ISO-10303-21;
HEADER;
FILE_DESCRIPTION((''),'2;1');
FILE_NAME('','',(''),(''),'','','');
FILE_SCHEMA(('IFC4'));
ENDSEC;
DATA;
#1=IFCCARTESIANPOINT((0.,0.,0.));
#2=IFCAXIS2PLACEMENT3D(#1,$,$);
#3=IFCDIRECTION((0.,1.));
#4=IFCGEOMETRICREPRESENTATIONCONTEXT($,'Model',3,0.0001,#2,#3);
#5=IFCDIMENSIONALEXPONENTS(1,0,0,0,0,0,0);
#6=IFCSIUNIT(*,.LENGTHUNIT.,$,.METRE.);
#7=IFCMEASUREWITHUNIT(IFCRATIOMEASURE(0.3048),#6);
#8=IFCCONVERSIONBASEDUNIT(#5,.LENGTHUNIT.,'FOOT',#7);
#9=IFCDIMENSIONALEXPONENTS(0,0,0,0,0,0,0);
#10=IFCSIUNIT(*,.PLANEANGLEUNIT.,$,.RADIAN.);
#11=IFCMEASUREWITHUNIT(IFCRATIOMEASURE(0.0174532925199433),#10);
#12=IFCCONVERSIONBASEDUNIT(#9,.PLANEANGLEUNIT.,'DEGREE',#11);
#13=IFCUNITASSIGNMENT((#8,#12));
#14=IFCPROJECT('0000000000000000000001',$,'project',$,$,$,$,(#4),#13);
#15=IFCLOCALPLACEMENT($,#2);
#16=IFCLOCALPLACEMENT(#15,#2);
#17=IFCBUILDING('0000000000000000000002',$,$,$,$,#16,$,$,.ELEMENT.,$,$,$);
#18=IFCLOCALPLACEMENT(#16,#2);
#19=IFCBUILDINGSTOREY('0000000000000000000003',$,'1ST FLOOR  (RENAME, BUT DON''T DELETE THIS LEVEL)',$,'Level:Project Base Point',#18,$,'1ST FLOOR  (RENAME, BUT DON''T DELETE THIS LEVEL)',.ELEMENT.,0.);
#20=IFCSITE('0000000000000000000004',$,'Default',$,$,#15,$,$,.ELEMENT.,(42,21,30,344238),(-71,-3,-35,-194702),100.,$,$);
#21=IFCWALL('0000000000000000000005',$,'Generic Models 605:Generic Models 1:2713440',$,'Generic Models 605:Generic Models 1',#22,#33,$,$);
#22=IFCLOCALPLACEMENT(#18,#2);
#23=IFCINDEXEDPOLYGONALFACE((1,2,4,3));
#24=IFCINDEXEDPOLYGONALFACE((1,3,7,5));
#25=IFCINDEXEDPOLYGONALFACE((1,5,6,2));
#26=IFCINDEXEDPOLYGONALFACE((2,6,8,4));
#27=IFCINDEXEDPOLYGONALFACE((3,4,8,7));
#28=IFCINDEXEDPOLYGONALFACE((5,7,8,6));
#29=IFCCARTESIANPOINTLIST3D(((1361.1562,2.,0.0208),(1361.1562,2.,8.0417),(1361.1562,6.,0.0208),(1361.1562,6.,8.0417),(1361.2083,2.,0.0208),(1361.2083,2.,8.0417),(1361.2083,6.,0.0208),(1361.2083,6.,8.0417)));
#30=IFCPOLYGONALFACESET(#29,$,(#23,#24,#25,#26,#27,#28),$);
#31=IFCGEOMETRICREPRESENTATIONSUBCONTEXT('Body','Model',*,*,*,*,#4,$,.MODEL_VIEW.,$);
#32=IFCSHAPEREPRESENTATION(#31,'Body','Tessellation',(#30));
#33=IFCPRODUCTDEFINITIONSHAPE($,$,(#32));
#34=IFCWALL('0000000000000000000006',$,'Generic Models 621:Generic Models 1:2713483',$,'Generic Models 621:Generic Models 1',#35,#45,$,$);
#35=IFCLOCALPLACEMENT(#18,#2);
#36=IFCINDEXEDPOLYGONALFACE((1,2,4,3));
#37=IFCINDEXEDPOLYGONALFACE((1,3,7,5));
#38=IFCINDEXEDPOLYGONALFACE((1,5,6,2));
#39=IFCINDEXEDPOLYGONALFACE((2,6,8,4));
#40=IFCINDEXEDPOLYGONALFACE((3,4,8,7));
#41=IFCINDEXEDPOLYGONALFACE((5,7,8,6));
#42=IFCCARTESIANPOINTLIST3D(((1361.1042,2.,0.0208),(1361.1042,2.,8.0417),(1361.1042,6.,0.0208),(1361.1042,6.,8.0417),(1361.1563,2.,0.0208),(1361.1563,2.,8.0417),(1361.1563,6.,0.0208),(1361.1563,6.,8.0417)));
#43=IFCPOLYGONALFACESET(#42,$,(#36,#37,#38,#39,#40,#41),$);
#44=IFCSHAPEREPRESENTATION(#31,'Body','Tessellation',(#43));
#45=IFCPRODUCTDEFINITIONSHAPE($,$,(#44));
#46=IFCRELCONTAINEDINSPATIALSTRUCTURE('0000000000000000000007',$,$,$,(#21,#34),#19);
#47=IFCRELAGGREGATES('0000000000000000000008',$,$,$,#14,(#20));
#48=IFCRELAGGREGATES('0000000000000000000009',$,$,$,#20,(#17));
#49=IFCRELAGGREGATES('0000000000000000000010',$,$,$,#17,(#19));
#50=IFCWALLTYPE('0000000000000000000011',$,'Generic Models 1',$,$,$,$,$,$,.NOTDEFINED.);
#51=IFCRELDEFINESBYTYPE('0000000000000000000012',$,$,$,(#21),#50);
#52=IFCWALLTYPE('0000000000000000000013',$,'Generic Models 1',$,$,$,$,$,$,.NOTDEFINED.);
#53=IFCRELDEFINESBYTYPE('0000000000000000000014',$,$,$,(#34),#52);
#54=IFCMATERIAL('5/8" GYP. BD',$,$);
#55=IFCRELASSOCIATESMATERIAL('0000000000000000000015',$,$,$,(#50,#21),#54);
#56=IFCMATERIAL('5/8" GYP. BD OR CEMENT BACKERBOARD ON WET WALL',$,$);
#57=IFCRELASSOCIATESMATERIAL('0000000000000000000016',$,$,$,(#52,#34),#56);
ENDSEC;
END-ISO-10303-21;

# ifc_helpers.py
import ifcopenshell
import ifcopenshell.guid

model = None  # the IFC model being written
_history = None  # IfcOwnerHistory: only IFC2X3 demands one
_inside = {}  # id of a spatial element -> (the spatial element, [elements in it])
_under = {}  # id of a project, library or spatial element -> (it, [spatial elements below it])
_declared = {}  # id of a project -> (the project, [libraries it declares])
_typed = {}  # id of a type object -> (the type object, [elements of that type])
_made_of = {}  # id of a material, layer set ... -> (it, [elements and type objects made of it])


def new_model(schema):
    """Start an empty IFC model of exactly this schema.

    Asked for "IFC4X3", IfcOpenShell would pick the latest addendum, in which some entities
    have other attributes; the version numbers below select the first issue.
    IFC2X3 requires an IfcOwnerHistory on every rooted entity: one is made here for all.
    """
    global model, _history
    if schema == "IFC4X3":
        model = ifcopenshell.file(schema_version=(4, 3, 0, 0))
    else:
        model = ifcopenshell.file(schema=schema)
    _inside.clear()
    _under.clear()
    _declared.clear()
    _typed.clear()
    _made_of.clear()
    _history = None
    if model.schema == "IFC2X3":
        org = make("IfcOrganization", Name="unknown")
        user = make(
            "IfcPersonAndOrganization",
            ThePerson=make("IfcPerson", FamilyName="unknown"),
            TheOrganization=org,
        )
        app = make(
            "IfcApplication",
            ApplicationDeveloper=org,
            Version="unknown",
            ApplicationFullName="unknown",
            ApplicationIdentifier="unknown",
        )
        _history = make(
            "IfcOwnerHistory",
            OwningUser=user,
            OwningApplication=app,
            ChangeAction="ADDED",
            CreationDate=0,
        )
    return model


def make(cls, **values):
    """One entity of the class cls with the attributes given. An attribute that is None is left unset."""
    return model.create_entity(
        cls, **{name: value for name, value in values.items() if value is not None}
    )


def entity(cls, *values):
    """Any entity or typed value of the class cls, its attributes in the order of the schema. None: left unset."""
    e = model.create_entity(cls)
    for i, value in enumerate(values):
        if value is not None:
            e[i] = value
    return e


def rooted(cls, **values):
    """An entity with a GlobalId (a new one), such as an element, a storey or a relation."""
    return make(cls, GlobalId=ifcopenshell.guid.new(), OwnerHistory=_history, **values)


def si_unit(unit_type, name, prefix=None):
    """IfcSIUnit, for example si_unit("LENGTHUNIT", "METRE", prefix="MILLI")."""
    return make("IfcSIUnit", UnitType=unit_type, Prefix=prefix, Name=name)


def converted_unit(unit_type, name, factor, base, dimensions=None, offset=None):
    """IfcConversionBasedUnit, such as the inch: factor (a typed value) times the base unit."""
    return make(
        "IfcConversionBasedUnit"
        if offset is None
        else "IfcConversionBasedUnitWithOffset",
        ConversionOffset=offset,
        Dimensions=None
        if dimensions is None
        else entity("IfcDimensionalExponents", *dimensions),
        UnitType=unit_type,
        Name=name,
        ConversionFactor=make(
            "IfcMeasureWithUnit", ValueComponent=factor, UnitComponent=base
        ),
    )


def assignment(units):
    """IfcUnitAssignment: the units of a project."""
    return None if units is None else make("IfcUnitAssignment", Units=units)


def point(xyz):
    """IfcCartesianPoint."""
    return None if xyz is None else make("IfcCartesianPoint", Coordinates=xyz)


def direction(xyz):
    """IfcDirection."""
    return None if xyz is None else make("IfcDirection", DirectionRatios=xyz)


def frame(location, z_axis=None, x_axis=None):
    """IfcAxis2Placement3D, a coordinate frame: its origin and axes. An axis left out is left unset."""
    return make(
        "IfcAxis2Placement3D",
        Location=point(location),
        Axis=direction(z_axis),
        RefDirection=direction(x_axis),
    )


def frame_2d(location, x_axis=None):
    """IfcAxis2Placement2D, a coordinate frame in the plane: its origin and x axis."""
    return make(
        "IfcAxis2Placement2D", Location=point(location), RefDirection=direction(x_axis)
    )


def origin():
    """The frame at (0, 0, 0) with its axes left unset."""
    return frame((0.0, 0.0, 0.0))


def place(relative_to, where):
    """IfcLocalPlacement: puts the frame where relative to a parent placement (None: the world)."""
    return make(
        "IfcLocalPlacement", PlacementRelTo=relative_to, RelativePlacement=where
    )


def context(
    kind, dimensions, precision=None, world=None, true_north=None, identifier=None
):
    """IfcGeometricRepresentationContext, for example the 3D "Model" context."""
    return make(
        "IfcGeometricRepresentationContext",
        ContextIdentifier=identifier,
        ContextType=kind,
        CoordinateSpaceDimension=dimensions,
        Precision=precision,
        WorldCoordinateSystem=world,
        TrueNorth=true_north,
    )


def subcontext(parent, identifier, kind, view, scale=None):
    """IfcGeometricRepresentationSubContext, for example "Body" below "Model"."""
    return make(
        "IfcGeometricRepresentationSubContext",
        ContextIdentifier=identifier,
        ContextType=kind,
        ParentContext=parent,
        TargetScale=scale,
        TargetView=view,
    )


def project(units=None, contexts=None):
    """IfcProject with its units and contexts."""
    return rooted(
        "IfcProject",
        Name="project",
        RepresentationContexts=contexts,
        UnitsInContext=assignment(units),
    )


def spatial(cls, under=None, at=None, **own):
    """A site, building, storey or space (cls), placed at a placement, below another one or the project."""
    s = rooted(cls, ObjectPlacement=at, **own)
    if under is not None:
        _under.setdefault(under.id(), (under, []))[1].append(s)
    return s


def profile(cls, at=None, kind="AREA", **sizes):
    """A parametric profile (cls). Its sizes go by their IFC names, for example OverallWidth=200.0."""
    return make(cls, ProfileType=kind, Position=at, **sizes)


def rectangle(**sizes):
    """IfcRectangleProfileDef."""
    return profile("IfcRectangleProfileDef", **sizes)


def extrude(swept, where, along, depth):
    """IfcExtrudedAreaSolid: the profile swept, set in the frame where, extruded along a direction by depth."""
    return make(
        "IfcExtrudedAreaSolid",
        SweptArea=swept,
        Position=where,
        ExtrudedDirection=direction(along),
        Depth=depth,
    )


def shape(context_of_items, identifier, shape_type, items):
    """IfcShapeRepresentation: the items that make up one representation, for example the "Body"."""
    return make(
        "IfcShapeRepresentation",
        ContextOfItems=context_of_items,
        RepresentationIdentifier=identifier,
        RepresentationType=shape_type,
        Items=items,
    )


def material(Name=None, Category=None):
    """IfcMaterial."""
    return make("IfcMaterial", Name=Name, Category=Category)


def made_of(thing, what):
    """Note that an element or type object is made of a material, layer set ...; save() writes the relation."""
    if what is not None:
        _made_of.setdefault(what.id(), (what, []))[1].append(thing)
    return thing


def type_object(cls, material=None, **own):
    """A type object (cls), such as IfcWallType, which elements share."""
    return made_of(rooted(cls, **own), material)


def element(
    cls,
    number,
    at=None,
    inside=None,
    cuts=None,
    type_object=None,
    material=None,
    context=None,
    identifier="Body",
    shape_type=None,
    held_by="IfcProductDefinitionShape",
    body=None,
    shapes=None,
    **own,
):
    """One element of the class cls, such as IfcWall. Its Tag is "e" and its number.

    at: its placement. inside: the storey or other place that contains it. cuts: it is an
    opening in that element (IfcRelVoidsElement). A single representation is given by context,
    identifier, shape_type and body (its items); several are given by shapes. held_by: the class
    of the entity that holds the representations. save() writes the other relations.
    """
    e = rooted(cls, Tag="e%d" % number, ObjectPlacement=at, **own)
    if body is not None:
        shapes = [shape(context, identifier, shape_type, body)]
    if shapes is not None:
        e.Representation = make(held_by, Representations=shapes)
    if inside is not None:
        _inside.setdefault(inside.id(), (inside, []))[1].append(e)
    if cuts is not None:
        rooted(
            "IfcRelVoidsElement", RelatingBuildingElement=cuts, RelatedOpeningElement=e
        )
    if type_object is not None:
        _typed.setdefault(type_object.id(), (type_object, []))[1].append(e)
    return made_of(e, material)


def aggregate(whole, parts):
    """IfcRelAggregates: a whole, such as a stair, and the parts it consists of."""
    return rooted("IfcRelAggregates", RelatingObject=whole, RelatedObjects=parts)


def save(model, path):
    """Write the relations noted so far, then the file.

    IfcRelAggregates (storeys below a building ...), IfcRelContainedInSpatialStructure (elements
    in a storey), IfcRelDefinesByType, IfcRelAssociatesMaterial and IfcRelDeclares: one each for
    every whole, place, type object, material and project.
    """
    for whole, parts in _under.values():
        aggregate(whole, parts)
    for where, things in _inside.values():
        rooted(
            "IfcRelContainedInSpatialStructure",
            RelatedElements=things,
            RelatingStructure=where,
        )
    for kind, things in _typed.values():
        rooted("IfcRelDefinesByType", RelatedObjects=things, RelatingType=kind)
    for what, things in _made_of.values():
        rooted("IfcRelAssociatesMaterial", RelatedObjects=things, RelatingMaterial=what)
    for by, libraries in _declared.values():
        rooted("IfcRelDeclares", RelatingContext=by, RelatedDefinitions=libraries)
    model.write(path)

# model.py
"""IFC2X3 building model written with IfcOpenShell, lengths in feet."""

from ifc_helpers import new_model, entity, si_unit, converted_unit, direction, frame, frame_2d, origin, place, context, subcontext, project, spatial, rectangle, extrude, material, type_object, element, save


model = new_model("IFC2X3")

# Units and contexts
model_context = context("Model", 3, precision=0.0001, world=origin(), true_north=direction((0.0, 1.0)))
body_context = subcontext(model_context, "Body", "Model", "MODEL_VIEW")
ifc_project = project(units=[converted_unit("LENGTHUNIT", "FOOT", entity("IfcRatioMeasure", 0.3048), si_unit("LENGTHUNIT", "METRE"), dimensions=[1, 0, 0, 0, 0, 0, 0]), converted_unit("PLANEANGLEUNIT", "DEGREE", entity("IfcRatioMeasure", 0.0174532925199433), si_unit("PLANEANGLEUNIT", "RADIAN"), dimensions=[0, 0, 0, 0, 0, 0, 0])], contexts=[model_context])

# Site, building, storey
site_placement = place(None, origin())
site = spatial("IfcSite", under=ifc_project, at=site_placement, Name="Default", CompositionType="ELEMENT", RefLatitude=(42, 21, 30, 344238), RefLongitude=(-71, -3, -35, -194702), RefElevation=100.0)
building_placement = place(site_placement, origin())
building = spatial("IfcBuilding", under=site, at=building_placement, CompositionType="ELEMENT")
storey_placement = place(building_placement, origin())
storey = spatial("IfcBuildingStorey", under=building, at=storey_placement, Name="1ST FLOOR  (RENAME, BUT DON'T DELETE THIS LEVEL)", ObjectType="Level:Project Base Point", LongName="1ST FLOOR  (RENAME, BUT DON'T DELETE THIS LEVEL)", CompositionType="ELEMENT", Elevation=0.0)

# Walls
ifc_material_1 = material(Name="5/8\" GYP. BD OR CEMENT BACKERBOARD ON WET WALL")
ifc_material_2 = material(Name="5/8\" GYP. BD")
wall_type_1 = type_object("IfcWallType", Name="Generic Models 1", PredefinedType="NOTDEFINED", material=ifc_material_2)
wall_1_placement = place(storey_placement, frame((1361.1562, 2.0, 0.0208), z_axis=(0.0, 0.0, 1.0), x_axis=(0.0, 1.0, 0.0)))
element("IfcWall", 1, at=wall_1_placement, inside=storey, type_object=wall_type_1, material=ifc_material_2, Name="Generic Models 605:Generic Models 1:2713440", ObjectType="Generic Models 605:Generic Models 1", context=body_context, shape_type="SweptSolid", body=[
    extrude(rectangle(XDim=4.0, YDim=0.0521, at=frame_2d((0.0, 0.0), x_axis=(1.0, 0.0))), frame((2.0, -0.026, 0.0)), (0.0, 0.0, 1.0), 8.0208),
])
wall_type_2 = type_object("IfcWallType", Name="Generic Models 1", PredefinedType="NOTDEFINED", material=ifc_material_1)
wall_2_placement = place(storey_placement, frame((1361.1042, 2.0, 0.0208), z_axis=(0.0, 0.0, 1.0), x_axis=(0.0, 1.0, 0.0)))
element("IfcWall", 2, at=wall_2_placement, inside=storey, type_object=wall_type_2, material=ifc_material_1, Name="Generic Models 621:Generic Models 1:2713483", ObjectType="Generic Models 621:Generic Models 1", context=body_context, shape_type="SweptSolid", body=[
    extrude(rectangle(XDim=4.0, YDim=0.0521, at=frame_2d((0.0, 0.0), x_axis=(1.0, 0.0))), frame((2.0, -0.026, 0.0)), (0.0, 0.0, 1.0), 8.0208),
])

save(model, "model.ifc")
